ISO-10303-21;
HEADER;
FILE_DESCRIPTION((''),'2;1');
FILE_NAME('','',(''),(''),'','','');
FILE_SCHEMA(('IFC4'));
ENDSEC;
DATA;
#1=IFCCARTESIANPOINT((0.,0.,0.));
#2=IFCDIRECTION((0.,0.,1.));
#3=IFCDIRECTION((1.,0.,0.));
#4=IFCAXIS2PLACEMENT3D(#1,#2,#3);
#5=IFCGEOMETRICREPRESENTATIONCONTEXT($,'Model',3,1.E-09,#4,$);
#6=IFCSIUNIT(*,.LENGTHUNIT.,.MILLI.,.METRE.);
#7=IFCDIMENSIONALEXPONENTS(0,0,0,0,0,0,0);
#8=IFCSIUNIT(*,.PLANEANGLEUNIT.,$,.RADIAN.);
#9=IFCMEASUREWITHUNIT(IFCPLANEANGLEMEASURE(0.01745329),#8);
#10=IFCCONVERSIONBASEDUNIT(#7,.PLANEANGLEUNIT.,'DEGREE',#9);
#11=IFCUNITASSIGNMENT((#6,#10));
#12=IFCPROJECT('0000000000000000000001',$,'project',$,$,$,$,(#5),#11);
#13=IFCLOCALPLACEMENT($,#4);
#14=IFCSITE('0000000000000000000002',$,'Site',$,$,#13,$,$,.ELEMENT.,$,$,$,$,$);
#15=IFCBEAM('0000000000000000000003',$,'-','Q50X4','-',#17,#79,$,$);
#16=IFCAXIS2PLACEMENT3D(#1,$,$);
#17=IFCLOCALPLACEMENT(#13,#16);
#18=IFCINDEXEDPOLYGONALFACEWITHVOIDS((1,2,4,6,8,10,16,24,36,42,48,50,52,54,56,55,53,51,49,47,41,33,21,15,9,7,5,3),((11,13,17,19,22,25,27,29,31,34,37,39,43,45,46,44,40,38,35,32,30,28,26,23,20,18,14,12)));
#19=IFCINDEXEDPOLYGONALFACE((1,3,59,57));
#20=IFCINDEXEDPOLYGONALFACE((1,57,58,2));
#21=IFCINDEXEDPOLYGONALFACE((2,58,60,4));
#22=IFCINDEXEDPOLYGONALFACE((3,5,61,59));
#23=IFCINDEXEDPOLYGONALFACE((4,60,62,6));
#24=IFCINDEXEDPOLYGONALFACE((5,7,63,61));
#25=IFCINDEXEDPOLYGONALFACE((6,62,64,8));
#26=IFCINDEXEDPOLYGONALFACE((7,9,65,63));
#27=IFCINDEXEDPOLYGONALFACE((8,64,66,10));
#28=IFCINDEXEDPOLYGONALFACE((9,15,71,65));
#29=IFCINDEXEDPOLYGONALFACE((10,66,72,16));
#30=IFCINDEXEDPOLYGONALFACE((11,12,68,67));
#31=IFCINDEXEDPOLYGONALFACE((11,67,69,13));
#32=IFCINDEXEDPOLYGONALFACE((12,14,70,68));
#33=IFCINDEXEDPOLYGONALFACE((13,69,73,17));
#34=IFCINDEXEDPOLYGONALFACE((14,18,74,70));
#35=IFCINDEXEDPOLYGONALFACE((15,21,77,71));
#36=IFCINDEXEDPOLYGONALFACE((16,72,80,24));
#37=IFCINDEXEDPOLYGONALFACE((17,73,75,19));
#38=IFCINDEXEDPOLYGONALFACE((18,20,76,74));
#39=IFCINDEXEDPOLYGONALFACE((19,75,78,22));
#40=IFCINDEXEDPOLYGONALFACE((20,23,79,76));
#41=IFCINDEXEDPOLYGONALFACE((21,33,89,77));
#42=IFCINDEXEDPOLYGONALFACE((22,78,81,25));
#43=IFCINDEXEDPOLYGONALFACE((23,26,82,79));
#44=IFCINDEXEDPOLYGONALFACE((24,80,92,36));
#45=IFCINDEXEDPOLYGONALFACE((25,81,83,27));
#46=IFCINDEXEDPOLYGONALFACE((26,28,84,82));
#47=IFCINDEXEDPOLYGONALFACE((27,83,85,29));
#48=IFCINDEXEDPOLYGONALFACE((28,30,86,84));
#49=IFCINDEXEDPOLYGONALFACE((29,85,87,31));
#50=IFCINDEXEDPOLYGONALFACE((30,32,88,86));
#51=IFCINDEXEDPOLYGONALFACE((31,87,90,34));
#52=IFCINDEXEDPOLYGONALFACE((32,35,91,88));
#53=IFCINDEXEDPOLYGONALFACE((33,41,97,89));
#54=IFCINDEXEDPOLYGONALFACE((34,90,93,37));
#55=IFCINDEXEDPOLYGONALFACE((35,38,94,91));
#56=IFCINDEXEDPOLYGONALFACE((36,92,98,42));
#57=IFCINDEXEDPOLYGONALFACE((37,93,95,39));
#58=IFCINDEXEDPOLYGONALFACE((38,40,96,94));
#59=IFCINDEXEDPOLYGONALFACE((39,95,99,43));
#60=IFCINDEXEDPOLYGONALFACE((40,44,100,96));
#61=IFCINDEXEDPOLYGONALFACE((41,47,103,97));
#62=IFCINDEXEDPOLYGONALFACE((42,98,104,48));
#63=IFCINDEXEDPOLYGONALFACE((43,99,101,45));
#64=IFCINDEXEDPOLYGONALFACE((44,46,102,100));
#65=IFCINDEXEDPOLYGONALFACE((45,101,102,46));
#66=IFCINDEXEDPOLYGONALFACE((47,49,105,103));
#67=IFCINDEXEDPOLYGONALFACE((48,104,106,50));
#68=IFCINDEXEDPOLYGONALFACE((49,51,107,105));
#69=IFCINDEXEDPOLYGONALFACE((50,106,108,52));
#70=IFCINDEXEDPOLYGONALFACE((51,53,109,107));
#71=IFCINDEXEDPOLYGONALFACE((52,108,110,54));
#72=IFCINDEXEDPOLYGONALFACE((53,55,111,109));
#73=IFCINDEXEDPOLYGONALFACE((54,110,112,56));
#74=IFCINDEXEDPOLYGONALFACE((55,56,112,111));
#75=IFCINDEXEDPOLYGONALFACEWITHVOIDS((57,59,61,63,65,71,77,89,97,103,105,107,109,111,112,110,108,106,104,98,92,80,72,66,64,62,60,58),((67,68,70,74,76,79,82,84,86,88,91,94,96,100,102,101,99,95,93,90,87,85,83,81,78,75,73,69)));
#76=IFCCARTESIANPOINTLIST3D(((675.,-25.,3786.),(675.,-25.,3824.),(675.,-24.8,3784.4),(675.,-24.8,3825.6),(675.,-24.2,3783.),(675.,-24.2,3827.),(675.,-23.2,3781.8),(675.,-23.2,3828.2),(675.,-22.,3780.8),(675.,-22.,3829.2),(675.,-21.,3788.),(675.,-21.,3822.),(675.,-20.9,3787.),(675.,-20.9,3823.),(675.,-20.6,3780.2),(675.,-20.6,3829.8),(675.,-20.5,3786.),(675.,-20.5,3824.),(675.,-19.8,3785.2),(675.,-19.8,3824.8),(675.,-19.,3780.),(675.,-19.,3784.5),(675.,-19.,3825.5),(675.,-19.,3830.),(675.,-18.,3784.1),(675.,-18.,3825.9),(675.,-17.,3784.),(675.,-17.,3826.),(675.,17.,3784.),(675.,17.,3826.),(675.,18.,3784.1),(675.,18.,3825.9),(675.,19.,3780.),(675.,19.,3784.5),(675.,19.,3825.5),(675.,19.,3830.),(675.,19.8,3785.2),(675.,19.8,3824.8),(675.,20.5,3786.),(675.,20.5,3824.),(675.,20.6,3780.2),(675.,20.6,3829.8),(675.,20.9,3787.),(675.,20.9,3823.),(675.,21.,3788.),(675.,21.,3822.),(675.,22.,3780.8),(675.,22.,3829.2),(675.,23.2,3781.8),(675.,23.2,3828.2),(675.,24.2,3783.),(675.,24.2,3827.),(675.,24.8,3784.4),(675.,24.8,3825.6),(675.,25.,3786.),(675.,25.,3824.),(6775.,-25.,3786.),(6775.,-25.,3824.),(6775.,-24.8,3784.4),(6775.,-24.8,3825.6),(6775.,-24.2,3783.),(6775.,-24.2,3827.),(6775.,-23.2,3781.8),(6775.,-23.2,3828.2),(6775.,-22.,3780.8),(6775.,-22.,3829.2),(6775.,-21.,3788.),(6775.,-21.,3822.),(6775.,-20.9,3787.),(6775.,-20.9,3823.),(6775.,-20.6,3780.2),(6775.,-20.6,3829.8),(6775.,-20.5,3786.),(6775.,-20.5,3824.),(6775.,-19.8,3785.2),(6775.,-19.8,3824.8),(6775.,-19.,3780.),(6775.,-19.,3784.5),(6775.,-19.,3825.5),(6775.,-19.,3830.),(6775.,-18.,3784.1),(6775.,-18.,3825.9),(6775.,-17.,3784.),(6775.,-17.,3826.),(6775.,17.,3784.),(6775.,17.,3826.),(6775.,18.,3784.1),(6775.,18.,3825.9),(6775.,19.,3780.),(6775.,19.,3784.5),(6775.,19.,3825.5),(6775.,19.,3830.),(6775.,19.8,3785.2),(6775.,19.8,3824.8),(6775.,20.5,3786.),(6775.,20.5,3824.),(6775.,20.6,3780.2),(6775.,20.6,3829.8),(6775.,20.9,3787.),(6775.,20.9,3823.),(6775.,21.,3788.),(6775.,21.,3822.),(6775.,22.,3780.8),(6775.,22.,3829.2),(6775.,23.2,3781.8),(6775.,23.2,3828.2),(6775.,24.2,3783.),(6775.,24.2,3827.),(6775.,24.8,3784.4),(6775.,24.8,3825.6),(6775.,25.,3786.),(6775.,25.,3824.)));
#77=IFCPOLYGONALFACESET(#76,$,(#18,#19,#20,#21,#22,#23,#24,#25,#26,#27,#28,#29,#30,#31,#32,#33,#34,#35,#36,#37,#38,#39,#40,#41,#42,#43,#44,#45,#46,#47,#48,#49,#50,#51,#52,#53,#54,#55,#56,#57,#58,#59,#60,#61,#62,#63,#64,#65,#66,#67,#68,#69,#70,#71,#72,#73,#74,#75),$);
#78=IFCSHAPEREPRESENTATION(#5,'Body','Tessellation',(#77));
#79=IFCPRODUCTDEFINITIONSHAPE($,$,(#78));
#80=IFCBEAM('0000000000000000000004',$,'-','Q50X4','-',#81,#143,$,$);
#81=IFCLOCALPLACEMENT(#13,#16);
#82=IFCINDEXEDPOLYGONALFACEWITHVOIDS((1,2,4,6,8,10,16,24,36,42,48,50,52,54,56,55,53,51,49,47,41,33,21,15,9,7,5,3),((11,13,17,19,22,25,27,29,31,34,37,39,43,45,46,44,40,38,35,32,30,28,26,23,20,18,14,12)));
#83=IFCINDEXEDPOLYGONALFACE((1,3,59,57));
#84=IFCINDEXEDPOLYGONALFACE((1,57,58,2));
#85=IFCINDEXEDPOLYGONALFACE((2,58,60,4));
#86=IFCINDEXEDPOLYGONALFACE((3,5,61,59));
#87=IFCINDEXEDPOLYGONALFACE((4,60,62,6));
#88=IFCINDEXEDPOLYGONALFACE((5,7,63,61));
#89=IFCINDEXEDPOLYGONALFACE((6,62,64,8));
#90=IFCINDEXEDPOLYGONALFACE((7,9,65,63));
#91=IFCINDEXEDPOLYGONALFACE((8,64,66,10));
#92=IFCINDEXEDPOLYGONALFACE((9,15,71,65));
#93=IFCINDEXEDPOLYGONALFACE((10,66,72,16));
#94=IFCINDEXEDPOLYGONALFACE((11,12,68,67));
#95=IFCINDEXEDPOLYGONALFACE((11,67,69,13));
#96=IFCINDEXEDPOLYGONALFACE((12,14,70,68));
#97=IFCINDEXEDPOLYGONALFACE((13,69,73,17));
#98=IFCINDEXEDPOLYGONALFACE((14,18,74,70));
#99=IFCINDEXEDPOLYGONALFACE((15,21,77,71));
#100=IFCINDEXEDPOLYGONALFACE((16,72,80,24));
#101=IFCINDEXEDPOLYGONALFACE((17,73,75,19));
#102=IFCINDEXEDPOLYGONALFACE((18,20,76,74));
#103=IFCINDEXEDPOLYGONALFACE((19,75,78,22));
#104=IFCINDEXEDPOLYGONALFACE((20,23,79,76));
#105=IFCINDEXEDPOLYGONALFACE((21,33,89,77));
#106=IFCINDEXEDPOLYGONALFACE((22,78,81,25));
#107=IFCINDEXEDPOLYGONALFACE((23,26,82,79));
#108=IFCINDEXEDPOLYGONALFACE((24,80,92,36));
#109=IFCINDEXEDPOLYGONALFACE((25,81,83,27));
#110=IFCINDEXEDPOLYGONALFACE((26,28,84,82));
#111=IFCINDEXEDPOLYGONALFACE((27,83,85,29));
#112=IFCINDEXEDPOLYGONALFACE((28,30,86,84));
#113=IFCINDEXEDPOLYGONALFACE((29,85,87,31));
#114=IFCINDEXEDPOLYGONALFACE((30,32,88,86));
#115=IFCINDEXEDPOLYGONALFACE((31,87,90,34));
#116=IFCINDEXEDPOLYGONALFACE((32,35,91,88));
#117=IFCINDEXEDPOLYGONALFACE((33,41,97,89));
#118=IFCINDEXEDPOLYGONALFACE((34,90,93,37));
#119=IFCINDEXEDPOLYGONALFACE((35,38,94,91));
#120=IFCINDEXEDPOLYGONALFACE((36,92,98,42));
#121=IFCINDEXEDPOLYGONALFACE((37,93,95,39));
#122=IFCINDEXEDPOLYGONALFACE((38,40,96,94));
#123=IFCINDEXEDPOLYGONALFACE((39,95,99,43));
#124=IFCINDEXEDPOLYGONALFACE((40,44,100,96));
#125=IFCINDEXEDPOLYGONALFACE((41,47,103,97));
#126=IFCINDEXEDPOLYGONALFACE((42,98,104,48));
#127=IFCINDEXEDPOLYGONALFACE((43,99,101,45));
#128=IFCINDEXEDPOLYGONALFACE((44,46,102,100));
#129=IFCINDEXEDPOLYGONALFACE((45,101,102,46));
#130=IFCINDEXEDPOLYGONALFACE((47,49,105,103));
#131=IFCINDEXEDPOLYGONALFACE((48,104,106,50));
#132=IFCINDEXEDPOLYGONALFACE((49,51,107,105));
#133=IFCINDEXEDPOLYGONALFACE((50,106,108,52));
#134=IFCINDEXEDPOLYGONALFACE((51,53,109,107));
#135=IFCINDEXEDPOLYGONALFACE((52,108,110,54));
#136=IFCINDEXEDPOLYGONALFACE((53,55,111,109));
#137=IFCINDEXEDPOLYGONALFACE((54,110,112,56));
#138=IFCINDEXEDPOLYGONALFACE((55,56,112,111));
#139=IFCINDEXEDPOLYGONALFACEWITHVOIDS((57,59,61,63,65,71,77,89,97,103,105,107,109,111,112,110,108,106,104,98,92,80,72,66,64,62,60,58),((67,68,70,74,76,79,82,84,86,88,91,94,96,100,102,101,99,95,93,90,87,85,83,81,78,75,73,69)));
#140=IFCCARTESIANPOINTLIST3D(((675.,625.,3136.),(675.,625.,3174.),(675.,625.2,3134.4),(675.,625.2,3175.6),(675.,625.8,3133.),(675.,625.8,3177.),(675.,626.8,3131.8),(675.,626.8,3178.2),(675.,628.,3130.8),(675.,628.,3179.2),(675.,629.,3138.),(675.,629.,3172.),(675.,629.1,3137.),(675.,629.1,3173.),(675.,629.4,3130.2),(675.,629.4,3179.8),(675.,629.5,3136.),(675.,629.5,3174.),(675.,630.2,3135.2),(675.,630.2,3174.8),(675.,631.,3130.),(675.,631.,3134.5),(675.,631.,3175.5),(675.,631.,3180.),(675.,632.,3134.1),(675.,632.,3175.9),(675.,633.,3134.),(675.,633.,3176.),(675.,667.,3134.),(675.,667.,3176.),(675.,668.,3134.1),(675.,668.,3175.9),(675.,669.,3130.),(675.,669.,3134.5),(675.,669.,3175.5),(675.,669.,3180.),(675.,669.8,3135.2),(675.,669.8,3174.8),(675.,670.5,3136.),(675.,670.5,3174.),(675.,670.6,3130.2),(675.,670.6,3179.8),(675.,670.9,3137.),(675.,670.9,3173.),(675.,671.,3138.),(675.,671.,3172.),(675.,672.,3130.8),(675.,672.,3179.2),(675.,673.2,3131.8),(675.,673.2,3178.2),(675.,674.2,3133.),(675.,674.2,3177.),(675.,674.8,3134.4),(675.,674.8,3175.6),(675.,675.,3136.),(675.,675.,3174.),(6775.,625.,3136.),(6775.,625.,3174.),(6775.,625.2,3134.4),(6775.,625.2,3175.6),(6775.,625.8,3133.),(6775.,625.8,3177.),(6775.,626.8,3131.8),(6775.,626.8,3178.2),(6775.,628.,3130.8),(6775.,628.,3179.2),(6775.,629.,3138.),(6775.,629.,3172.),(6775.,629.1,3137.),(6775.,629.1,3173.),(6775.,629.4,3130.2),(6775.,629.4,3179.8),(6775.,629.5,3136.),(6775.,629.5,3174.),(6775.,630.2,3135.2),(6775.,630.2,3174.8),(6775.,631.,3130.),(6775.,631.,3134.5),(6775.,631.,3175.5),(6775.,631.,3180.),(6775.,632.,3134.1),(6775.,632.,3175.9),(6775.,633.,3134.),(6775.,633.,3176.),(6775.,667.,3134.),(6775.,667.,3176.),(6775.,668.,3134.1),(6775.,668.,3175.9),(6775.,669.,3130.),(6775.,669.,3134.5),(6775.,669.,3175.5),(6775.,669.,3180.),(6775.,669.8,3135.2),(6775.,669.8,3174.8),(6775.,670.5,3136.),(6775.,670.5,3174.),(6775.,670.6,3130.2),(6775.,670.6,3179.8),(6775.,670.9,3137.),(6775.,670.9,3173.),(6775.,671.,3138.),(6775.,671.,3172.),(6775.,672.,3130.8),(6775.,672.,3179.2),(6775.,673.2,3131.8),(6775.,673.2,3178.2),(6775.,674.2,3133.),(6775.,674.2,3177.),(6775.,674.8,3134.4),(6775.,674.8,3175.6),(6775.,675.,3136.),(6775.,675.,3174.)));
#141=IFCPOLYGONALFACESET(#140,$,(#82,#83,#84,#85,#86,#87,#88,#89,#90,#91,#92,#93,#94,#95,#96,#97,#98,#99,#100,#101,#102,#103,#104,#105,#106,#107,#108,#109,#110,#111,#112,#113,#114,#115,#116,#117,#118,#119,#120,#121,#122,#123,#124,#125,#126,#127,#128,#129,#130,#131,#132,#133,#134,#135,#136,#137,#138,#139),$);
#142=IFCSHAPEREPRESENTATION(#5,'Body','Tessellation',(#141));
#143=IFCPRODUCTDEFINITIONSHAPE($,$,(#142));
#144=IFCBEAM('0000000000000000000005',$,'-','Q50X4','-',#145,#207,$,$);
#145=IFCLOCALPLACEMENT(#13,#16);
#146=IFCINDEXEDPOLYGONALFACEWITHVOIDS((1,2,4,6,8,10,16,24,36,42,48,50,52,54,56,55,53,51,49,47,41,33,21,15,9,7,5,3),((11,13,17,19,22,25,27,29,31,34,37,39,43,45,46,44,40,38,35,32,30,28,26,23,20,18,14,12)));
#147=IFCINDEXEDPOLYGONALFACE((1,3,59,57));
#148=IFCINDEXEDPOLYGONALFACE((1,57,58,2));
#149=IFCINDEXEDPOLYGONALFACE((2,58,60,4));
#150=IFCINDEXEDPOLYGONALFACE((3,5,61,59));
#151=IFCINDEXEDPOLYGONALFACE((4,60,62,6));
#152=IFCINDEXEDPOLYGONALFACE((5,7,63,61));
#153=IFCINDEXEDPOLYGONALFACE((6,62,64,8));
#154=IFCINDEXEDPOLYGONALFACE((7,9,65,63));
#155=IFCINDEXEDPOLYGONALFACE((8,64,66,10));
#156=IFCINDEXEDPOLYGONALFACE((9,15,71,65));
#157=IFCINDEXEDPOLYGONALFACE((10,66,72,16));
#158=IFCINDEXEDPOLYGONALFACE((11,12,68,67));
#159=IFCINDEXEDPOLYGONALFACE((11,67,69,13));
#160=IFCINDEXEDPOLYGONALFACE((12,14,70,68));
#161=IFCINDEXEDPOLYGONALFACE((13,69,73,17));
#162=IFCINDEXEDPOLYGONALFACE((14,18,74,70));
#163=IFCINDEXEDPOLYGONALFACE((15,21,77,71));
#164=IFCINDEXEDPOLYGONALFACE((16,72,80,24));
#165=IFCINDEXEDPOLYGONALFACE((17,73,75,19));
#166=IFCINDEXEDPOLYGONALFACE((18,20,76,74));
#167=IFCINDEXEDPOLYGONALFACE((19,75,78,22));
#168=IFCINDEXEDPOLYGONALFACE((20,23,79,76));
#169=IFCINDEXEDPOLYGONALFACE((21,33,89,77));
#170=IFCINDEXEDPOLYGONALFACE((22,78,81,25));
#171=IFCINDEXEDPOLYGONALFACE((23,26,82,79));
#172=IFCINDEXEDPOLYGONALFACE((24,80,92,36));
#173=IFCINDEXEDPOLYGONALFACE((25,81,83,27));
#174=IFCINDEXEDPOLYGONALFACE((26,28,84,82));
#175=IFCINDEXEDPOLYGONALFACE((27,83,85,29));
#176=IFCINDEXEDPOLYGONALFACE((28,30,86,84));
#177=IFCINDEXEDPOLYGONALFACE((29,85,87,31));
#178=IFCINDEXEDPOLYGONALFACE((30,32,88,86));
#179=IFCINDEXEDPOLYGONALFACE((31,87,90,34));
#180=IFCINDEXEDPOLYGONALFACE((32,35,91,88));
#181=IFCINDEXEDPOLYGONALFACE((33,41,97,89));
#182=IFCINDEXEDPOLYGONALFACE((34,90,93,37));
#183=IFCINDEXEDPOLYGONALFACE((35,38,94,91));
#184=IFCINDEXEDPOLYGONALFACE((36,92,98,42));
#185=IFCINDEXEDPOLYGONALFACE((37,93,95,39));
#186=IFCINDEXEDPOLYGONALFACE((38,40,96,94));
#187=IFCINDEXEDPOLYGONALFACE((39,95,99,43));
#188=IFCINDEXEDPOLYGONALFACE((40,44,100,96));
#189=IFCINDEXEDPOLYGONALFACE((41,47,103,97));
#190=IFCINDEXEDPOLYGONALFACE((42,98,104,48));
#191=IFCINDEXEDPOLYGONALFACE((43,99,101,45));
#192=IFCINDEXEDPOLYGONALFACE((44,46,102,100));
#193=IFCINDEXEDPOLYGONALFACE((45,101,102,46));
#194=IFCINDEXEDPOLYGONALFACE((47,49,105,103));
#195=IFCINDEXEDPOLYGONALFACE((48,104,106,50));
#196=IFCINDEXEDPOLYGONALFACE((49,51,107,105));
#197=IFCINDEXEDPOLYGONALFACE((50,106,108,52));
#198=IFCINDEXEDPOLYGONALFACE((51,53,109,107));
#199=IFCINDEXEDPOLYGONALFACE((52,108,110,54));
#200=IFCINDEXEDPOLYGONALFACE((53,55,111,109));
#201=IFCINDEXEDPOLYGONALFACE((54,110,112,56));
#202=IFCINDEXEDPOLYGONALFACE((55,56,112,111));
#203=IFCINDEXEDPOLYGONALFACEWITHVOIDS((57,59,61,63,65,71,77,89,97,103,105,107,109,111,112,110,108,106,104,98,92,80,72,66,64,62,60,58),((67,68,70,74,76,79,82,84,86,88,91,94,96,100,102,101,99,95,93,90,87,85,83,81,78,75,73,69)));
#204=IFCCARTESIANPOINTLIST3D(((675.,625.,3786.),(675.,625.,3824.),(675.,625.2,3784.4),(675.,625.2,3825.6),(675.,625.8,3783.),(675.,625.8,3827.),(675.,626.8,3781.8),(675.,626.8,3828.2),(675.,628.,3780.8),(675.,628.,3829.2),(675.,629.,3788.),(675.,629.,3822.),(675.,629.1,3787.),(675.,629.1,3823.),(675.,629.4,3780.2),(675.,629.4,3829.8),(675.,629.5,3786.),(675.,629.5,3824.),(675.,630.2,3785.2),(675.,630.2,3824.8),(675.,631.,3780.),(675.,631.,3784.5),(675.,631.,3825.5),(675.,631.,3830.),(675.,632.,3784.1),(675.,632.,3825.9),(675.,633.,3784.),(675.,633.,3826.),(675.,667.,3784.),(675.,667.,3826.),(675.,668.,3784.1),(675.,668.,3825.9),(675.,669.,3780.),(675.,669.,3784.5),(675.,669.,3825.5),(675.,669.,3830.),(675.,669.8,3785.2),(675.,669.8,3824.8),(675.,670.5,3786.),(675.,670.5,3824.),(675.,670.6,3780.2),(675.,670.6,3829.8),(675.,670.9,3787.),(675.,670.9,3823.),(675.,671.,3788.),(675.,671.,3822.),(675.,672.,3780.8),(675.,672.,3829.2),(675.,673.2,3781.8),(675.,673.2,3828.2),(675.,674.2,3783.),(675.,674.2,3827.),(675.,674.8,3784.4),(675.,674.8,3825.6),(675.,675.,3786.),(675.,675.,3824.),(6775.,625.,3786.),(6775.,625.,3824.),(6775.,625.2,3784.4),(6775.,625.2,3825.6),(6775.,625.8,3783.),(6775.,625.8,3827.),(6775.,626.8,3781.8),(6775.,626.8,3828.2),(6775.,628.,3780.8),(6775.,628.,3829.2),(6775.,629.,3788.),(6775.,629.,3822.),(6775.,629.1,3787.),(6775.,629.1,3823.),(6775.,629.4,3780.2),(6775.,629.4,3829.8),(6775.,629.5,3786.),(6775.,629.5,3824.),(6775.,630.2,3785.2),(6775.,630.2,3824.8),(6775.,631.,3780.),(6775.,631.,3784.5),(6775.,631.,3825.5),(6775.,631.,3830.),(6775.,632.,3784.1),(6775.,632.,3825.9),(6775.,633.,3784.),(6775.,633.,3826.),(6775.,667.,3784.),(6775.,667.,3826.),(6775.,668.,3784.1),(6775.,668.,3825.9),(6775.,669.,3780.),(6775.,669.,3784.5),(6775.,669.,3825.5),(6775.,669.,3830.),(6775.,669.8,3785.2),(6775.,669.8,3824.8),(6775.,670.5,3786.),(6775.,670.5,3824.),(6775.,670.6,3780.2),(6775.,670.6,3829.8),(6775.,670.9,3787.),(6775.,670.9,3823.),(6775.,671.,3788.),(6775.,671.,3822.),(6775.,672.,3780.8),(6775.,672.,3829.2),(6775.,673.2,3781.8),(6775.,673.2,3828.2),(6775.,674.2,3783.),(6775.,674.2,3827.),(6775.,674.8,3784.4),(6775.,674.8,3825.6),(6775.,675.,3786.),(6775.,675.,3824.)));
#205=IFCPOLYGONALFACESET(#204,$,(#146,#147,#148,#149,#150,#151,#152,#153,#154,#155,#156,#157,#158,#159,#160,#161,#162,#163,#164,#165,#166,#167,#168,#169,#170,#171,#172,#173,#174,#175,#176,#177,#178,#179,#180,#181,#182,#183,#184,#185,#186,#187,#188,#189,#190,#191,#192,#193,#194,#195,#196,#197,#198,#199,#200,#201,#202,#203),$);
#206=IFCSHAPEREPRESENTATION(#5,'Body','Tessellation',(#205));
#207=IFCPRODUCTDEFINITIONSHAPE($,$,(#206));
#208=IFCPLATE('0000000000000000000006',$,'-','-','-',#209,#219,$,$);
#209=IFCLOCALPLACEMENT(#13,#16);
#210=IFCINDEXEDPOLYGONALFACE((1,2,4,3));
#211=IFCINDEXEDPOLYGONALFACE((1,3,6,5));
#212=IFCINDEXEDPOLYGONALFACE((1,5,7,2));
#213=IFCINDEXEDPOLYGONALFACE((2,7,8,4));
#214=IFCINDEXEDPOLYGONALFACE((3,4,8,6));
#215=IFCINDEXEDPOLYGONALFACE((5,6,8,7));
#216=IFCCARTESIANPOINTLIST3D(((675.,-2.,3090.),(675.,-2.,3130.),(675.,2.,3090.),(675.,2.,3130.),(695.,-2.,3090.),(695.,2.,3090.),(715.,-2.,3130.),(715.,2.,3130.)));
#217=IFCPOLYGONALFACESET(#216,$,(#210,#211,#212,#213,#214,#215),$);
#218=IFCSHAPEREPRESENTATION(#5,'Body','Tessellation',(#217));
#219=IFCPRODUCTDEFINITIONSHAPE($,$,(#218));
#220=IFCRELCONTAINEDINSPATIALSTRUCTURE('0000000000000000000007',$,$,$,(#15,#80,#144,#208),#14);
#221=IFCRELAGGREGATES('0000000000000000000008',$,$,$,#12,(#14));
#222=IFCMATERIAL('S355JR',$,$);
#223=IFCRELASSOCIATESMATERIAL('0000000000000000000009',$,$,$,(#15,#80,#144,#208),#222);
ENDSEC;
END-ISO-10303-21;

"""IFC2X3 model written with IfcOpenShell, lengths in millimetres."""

from ifc_helpers import new_model, entity, si_unit, converted_unit, frame, origin, origin_with_axes, origin_2d, place, context, project, spatial, polyline, hollow_rectangle, outline, extrude, material, element, save


model = new_model("IFC2X3")

# Units and contexts
model_context = context("Model", 3, precision=1e-09, world=origin_with_axes())
ifc_project = project(units=[si_unit("LENGTHUNIT", "METRE", prefix="MILLI"), converted_unit("PLANEANGLEUNIT", "DEGREE", entity("IfcPlaneAngleMeasure", 0.01745329), si_unit("PLANEANGLEUNIT", "RADIAN"), dimensions=[0, 0, 0, 0, 0, 0, 0])], contexts=[model_context])

# Site
site_placement = place(None, origin_with_axes())
site = spatial("IfcSite", under=ifc_project, at=site_placement, Name="Site", CompositionType="ELEMENT")

# Shared definitions
ifc_material_1 = material(Name="S355JR")

# Beams
for number, where, z_axis, x_axis, name in (
    (1, (675.0, 0.0, 3805.0), (-1.0, 0.0, 0.0), (0.0, -1.0, 0.0), "-"),
    (2, (675.0, 650.0, 3155.0), (-1.0, 0.0, 0.0), (0.0, -1.0, 0.0), "-"),
    (3, (675.0, 650.0, 3805.0), (-1.0, 0.0, 0.0), (0.0, -1.0, 0.0), "-"),
):
    element("IfcBeam", number, at=place(None, frame(where, z_axis=z_axis, x_axis=x_axis)), inside=site, material=ifc_material_1, Name=name, Description="Q50X4", ObjectType="-", context=model_context, shape_type="SweptSolid", body=[
        extrude(hollow_rectangle(XDim=50.0, YDim=50.0, WallThickness=4.0, InnerFilletRadius=4.0, OuterFilletRadius=6.0, at=origin_2d()), origin(), (0.0, 0.0, -1.0), 6100.0),
    ])

# Plate
for number, where, z_axis, x_axis, name in (
    (4, (675.0, -2.0, 3130.0), (0.0, -1.0, 0.0), (0.0, 0.0, -1.0), "-"),
):
    element("IfcPlate", number, at=place(None, frame(where, z_axis=z_axis, x_axis=x_axis)), inside=site, material=ifc_material_1, Name=name, Description="-", ObjectType="-", context=model_context, shape_type="SweptSolid", body=[
        extrude(outline(polyline([(0.0, 0.0), (40.0, 0.0), (40.0, 20.0), (0.0, 40.0), (0.0, 0.0)])), origin_with_axes(), (0.0, 0.0, -1.0), 4.0),
    ])

save(model, "model.ifc")
